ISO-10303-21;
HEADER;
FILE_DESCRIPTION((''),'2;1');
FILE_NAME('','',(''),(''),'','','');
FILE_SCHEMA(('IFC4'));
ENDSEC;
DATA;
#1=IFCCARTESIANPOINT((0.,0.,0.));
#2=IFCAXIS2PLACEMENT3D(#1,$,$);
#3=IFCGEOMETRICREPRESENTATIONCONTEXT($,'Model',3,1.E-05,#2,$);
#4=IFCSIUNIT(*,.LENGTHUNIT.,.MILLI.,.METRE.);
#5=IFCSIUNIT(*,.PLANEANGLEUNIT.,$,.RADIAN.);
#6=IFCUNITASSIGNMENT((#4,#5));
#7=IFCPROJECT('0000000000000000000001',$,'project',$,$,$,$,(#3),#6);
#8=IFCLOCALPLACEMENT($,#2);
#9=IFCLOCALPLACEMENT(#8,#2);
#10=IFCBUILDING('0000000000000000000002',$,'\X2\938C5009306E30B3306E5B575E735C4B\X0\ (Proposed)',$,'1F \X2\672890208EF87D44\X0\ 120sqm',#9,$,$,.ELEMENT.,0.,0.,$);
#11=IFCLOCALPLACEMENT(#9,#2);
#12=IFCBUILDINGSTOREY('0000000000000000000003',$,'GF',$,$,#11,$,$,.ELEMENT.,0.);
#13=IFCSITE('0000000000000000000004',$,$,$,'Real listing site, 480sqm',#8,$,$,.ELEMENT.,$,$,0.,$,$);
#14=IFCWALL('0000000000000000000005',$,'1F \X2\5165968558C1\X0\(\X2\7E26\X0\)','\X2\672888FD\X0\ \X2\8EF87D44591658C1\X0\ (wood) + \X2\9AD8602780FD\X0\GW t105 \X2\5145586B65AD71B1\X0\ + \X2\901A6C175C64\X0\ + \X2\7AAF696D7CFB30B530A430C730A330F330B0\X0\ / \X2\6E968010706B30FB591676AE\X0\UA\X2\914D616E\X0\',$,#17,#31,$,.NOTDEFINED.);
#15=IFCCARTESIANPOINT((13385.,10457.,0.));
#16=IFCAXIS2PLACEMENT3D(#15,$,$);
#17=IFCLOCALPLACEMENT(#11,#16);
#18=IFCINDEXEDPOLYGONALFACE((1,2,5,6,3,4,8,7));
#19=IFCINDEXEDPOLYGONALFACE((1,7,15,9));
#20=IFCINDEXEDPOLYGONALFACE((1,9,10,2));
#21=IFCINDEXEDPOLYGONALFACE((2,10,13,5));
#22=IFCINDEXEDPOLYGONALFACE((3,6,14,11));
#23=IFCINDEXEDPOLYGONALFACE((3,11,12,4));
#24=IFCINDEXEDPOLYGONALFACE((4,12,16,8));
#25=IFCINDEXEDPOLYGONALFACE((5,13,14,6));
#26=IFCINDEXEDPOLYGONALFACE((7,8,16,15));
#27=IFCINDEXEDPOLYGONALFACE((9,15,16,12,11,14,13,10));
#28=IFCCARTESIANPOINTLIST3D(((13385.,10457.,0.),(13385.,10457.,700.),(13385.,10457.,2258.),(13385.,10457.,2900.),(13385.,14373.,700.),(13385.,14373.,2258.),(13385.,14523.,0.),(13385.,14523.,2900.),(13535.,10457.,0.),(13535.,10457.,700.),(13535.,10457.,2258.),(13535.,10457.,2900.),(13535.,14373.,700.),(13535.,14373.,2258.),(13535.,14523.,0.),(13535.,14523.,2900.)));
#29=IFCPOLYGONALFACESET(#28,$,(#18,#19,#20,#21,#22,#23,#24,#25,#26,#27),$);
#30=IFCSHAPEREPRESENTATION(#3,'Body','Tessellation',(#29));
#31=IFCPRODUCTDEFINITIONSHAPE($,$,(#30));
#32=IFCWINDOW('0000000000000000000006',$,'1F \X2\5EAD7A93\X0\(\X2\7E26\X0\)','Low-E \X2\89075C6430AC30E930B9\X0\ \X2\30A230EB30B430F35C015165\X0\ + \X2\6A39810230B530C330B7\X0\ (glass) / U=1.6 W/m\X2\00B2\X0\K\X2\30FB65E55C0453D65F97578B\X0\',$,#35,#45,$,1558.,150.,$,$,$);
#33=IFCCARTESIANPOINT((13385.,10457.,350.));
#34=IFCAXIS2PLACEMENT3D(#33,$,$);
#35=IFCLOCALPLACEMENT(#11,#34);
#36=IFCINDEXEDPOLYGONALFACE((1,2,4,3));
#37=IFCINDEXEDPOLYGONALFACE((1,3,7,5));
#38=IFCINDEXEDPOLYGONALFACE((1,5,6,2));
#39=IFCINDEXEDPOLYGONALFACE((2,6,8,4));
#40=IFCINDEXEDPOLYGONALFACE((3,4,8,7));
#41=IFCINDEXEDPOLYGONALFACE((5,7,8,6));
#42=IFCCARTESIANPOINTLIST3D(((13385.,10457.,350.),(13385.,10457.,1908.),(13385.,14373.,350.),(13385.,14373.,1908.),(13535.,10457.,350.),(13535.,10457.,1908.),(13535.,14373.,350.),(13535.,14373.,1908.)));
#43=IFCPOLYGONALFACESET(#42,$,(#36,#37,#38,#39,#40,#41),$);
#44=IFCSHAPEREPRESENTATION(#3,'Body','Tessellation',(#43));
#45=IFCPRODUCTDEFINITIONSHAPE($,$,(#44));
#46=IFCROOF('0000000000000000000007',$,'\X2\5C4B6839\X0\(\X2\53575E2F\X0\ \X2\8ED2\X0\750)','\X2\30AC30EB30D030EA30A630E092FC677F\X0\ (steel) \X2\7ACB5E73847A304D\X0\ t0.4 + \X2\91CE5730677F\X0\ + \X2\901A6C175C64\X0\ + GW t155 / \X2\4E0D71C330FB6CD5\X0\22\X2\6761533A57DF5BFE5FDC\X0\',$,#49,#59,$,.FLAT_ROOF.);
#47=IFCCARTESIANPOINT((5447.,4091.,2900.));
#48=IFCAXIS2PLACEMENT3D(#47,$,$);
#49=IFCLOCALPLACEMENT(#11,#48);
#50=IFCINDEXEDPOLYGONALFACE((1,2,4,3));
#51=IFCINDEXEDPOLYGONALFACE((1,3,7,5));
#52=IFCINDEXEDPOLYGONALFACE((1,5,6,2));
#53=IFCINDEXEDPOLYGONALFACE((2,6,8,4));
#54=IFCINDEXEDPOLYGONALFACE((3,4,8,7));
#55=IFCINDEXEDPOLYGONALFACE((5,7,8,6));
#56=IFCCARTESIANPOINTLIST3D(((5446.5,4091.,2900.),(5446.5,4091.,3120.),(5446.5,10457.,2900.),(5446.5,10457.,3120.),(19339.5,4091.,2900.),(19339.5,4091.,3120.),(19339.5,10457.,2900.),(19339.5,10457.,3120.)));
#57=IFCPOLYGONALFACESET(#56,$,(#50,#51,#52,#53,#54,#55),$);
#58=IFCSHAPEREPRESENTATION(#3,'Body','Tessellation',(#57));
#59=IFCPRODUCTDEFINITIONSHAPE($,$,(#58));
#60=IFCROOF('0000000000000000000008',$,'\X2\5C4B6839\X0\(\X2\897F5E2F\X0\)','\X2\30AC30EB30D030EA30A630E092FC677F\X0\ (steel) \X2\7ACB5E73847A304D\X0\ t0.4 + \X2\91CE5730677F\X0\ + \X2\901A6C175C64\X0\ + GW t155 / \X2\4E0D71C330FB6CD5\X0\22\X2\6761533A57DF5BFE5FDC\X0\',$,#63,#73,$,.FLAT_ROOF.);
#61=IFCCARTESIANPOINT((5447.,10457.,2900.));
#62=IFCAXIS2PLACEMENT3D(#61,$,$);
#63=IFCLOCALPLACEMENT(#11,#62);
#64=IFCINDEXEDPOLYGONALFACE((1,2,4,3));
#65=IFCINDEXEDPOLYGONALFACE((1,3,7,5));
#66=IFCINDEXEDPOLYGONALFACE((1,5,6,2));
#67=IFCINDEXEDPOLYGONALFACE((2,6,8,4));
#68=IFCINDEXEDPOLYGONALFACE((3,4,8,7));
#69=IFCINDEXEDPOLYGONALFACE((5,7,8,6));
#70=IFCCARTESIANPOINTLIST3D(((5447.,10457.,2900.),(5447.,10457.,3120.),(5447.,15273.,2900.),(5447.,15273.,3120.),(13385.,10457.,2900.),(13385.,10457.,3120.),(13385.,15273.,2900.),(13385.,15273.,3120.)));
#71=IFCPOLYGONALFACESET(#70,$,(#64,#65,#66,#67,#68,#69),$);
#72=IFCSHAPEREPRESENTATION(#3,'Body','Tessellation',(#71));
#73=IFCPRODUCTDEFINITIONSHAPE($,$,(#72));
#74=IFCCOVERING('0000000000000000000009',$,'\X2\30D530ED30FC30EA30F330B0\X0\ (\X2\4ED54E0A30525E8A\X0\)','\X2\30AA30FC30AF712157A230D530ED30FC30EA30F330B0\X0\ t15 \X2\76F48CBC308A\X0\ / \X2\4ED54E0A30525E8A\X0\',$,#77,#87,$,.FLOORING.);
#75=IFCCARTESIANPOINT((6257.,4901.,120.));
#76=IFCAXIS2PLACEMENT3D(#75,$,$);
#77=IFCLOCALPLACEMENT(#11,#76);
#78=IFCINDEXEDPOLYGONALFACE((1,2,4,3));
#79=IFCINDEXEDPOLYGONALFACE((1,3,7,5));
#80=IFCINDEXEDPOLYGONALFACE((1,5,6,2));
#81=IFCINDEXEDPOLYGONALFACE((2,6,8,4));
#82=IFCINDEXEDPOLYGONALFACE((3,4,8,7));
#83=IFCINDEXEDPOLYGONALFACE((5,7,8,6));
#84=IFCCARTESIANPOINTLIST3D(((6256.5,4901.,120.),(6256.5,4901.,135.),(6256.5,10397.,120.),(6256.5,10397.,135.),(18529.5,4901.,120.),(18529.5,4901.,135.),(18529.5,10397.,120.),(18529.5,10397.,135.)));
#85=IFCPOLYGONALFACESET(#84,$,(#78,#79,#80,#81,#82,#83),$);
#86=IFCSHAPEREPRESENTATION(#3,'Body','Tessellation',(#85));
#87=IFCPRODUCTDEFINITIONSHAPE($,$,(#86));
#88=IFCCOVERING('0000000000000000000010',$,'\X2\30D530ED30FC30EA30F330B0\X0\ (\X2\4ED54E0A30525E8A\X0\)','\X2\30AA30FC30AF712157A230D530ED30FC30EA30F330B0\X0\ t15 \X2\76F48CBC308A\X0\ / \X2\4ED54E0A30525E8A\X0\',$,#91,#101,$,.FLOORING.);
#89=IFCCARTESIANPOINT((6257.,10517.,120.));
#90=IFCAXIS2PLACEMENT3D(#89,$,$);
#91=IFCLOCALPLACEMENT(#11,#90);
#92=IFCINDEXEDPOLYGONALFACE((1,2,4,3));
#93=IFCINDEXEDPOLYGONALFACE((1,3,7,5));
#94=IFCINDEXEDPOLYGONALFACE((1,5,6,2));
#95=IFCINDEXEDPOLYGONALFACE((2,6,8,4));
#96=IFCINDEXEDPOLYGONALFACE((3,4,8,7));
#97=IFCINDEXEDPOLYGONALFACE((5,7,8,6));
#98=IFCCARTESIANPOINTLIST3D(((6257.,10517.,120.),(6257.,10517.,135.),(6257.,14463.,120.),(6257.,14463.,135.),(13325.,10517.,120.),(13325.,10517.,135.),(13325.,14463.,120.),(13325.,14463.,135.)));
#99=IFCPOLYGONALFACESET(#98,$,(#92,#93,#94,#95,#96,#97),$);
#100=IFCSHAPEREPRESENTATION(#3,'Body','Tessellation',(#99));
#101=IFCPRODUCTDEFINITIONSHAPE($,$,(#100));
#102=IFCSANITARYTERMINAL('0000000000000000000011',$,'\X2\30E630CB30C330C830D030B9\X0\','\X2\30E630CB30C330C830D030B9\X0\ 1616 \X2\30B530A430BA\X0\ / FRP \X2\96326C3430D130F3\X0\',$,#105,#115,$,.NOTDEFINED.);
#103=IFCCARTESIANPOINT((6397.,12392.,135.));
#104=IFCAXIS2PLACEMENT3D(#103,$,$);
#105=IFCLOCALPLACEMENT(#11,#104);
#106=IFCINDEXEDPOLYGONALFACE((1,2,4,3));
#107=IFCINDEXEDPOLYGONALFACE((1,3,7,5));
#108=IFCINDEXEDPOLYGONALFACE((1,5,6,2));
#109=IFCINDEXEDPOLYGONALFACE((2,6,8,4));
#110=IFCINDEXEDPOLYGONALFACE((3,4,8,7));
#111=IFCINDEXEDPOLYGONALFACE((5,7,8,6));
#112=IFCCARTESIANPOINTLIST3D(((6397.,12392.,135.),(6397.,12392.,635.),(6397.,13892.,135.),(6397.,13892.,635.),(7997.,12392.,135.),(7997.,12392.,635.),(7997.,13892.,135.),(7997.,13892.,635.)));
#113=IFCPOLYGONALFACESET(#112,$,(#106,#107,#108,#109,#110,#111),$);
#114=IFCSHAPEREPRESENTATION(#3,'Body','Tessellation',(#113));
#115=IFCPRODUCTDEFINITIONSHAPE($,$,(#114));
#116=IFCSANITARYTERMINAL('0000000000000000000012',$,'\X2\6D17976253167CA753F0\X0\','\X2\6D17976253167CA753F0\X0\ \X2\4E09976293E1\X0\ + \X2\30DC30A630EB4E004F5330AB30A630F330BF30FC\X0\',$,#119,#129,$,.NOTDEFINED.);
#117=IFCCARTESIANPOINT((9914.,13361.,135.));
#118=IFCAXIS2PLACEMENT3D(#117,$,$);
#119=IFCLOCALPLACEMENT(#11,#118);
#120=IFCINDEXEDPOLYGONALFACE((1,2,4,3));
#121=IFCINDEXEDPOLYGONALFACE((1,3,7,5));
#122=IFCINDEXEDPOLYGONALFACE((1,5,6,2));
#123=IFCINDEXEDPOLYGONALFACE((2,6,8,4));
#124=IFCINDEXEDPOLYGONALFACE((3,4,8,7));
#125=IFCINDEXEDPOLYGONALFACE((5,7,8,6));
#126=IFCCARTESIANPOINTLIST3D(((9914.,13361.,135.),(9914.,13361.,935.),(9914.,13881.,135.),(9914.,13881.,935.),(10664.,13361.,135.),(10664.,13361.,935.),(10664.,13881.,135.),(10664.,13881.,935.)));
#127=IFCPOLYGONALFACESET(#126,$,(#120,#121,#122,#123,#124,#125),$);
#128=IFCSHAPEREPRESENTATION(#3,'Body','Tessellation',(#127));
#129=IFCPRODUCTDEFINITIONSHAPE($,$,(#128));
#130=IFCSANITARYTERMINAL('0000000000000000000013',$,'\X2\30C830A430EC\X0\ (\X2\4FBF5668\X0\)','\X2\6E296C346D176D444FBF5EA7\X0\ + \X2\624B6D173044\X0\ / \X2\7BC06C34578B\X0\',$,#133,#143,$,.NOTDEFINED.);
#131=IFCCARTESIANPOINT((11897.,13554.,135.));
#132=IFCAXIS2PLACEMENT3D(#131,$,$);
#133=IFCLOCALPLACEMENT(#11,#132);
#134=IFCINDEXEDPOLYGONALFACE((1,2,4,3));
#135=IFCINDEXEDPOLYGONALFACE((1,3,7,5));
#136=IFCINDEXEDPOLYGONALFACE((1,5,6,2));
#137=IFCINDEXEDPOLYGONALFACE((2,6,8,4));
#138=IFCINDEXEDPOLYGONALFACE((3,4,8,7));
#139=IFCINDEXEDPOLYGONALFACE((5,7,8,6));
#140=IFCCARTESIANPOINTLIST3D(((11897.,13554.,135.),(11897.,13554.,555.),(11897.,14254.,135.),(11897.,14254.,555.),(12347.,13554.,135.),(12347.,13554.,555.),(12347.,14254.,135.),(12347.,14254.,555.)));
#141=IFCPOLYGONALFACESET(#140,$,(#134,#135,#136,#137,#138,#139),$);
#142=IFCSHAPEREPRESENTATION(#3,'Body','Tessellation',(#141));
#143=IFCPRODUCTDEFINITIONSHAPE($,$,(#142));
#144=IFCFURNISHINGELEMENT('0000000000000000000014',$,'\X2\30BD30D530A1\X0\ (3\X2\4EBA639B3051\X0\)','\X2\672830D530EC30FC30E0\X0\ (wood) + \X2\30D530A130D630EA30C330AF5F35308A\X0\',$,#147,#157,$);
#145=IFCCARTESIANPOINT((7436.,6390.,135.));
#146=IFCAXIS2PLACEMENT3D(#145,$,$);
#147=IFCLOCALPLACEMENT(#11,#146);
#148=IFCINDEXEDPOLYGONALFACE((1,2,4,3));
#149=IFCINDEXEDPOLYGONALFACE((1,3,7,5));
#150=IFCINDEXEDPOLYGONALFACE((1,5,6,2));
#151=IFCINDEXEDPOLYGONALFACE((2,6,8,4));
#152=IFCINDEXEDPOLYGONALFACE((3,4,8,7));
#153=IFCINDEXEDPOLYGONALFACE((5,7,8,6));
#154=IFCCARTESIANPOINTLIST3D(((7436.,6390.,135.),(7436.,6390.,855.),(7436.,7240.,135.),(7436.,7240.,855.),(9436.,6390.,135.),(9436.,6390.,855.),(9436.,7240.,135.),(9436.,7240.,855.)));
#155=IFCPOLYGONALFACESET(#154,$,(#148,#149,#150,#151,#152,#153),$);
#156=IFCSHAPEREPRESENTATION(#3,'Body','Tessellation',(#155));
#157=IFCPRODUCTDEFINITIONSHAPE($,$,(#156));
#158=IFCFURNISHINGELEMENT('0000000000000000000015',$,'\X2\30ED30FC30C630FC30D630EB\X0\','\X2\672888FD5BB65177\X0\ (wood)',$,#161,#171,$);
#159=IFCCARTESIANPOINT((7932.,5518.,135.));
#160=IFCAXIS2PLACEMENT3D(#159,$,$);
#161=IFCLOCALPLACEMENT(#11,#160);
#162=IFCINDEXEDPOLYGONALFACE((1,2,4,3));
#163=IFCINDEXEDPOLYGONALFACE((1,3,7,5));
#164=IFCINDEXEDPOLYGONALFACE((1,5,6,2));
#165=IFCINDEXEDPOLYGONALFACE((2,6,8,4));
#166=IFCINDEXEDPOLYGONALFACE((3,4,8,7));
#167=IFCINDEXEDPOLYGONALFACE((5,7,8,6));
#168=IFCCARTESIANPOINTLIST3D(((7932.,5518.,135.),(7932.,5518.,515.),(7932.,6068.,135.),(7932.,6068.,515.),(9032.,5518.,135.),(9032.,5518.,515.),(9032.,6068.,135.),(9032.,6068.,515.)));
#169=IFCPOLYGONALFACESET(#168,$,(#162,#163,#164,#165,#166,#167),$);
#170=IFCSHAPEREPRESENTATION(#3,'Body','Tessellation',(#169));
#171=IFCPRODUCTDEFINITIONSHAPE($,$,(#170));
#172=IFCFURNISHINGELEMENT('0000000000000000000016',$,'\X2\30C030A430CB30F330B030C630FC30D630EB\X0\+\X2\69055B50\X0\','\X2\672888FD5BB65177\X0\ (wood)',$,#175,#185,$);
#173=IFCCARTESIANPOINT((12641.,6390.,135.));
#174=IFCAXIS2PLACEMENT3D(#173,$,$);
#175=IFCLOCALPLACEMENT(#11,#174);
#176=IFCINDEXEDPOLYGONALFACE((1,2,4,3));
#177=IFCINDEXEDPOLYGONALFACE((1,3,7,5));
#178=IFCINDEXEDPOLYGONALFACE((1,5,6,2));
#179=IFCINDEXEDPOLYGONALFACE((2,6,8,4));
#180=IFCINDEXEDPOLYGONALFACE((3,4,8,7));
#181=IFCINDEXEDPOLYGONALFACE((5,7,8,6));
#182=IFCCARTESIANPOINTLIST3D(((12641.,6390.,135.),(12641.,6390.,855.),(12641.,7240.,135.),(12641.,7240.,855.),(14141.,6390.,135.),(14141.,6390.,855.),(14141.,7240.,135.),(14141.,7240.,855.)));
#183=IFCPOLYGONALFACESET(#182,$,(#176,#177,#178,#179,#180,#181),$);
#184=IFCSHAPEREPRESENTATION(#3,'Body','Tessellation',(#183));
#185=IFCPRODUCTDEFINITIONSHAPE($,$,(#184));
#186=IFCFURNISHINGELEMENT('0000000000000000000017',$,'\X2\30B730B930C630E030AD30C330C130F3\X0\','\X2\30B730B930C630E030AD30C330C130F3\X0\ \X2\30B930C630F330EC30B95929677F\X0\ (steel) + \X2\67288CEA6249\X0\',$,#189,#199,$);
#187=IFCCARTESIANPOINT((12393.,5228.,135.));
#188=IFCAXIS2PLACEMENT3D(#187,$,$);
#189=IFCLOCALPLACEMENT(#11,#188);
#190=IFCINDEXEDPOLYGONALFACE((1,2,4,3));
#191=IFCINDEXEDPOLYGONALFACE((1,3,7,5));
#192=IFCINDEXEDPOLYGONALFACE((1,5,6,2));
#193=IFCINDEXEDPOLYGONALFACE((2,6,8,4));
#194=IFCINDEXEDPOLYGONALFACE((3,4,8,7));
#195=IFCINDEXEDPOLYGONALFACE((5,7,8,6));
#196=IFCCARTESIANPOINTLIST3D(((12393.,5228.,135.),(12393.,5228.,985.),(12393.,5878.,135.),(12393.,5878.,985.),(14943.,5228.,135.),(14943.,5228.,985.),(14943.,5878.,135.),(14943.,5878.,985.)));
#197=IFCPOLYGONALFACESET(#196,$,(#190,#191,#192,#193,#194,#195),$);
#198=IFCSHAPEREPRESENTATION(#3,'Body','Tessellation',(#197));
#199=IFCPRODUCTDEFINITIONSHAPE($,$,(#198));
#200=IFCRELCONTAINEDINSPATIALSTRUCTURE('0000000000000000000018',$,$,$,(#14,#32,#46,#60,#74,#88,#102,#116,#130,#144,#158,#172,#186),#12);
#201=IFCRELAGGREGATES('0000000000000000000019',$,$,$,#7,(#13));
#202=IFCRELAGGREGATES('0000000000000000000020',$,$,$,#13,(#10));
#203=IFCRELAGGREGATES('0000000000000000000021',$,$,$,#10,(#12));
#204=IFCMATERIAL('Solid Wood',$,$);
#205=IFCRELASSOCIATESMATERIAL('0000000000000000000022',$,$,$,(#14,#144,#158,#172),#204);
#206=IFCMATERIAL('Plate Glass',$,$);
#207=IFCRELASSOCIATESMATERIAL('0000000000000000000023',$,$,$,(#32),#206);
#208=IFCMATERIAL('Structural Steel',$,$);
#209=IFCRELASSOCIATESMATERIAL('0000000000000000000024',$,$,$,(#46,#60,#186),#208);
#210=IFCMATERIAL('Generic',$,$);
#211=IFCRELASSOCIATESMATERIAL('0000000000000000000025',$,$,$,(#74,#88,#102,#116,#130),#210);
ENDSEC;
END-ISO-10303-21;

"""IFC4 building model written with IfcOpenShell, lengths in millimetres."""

from ifc_helpers import new_model, si_unit, frame, frame_2d, origin, place, context, project, spatial, rectangle, extrude, material, element, fill, save


model = new_model("IFC4")

# Units and contexts
model_context = context("Model", 3, precision=1e-05, world=origin())
ifc_project = project(units=[si_unit("LENGTHUNIT", "METRE", prefix="MILLI"), si_unit("PLANEANGLEUNIT", "RADIAN")], contexts=[model_context])

# Site, building, storey
site_placement = place(None, origin())
site = spatial("IfcSite", under=ifc_project, at=site_placement, ObjectType="Real listing site, 480sqm", CompositionType="ELEMENT", RefElevation=0.0)
building_placement = place(site_placement, origin())
building = spatial("IfcBuilding", under=site, at=building_placement, Name="鎌倉のコの字平屋 (Proposed)", ObjectType="1F 木造軸組 120sqm", CompositionType="ELEMENT", ElevationOfRefHeight=0.0, ElevationOfTerrain=0.0)
storey_placement = place(building_placement, origin())
storey = spatial("IfcBuildingStorey", under=building, at=storey_placement, Name="GF", CompositionType="ELEMENT", Elevation=0.0)

# Shared definitions
ifc_material_1 = material(Name="Solid Wood")

# Shared definitions
ifc_material_2 = material(Name="Plate Glass")

# Wall, opening, window
wall_1_placement = place(storey_placement, frame((13385.0, 10457.0, 0.0)))
wall_1 = element("IfcWall", 1, at=wall_1_placement, inside=storey, material=ifc_material_1, Name="1F 入隅壁(縦)", Description="木製 軸組外壁 (wood) + 高性能GW t105 充填断熱 + 通気層 + 窯業系サイディング / 準耐火・外皮UA配慮", PredefinedType="NOTDEFINED", context=model_context, shape_type="SweptSolid", body=[
    extrude(rectangle(XDim=150.0, YDim=4066.0, at=frame_2d((75.0, 2033.0))), frame((13385.0, 10457.0, 0.0)), (0.0, 0.0, 1.0), 2900.0),
])
opening_1_placement = place(storey_placement, frame((13385.0, 10457.0, 350.0)))
opening_1 = element("IfcOpeningElement", 2, at=opening_1_placement, cuts=wall_1, PredefinedType="NOTDEFINED", context=model_context, shape_type="SweptSolid", body=[
    extrude(rectangle(XDim=150.0, YDim=3916.0, at=frame_2d((75.0, 1958.0))), frame((13385.0, 10457.0, 350.0)), (0.0, 0.0, 1.0), 1558.0),
])
window_1_placement = place(storey_placement, frame((13385.0, 10457.0, 350.0)))
window_1 = element("IfcWindow", 3, at=window_1_placement, inside=storey, material=ifc_material_2, Name="1F 庭窓(縦)", Description="Low-E 複層ガラス アルゴン封入 + 樹脂サッシ (glass) / U=1.6 W/m²K・日射取得型", OverallHeight=1558.0, OverallWidth=150.0, context=model_context, shape_type="SweptSolid", body=[
    extrude(rectangle(XDim=150.0, YDim=3916.0, at=frame_2d((75.0, 1958.0))), frame((13385.0, 10457.0, 350.0)), (0.0, 0.0, 1.0), 1558.0),
])
fill(opening_1, window_1)

# Roofs
ifc_material_3 = material(Name="Structural Steel")
roof_1_placement = place(storey_placement, frame((5447.0, 4091.0, 2900.0)))
element("IfcRoof", 4, at=roof_1_placement, inside=storey, material=ifc_material_3, Name="屋根(南帯 軒750)", Description="ガルバリウム鋼板 (steel) 立平葺き t0.4 + 野地板 + 通気層 + GW t155 / 不燃・法22条区域対応", PredefinedType="FLAT_ROOF", context=model_context, shape_type="SweptSolid", body=[
    extrude(rectangle(XDim=13893.0, YDim=6366.0, at=frame_2d((6946.0, 3183.0))), frame((5447.0, 4091.0, 2900.0)), (0.0, 0.0, 1.0), 220.0),
])
roof_2_placement = place(storey_placement, frame((5447.0, 10457.0, 2900.0)))
element("IfcRoof", 5, at=roof_2_placement, inside=storey, material=ifc_material_3, Name="屋根(西帯)", Description="ガルバリウム鋼板 (steel) 立平葺き t0.4 + 野地板 + 通気層 + GW t155 / 不燃・法22条区域対応", PredefinedType="FLAT_ROOF", context=model_context, shape_type="SweptSolid", body=[
    extrude(rectangle(XDim=7938.0, YDim=4816.0, at=frame_2d((3969.0, 2408.0))), frame((5447.0, 10457.0, 2900.0)), (0.0, 0.0, 1.0), 220.0),
])

# Coverings
ifc_material_4 = material(Name="Generic")
covering_1_placement = place(storey_placement, frame((6257.0, 4901.0, 120.0)))
element("IfcCovering", 6, at=covering_1_placement, inside=storey, material=ifc_material_4, Name="フローリング (仕上げ床)", Description="オーク無垢フローリング t15 直貼り / 仕上げ床", PredefinedType="FLOORING", context=model_context, shape_type="SweptSolid", body=[
    extrude(rectangle(XDim=12273.0, YDim=5496.0, at=frame_2d((6136.0, 2748.0))), frame((6257.0, 4901.0, 120.0)), (0.0, 0.0, 1.0), 15.0),
])
covering_2_placement = place(storey_placement, frame((6257.0, 10517.0, 120.0)))
element("IfcCovering", 7, at=covering_2_placement, inside=storey, material=ifc_material_4, Name="フローリング (仕上げ床)", Description="オーク無垢フローリング t15 直貼り / 仕上げ床", PredefinedType="FLOORING", context=model_context, shape_type="SweptSolid", body=[
    extrude(rectangle(XDim=7068.0, YDim=3946.0, at=frame_2d((3534.0, 1973.0))), frame((6257.0, 10517.0, 120.0)), (0.0, 0.0, 1.0), 15.0),
])

# Sanitary terminals
sanitary_terminal_1_placement = place(storey_placement, frame((6397.0, 12392.0, 135.0)))
element("IfcSanitaryTerminal", 8, at=sanitary_terminal_1_placement, inside=storey, material=ifc_material_4, Name="ユニットバス", Description="ユニットバス 1616 サイズ / FRP 防水パン", PredefinedType="NOTDEFINED", context=model_context, shape_type="SweptSolid", body=[
    extrude(rectangle(XDim=1600.0, YDim=1500.0, at=frame_2d((800.0, 750.0))), frame((6397.0, 12392.0, 135.0)), (0.0, 0.0, 1.0), 500.0),
])
sanitary_terminal_2_placement = place(storey_placement, frame((9914.0, 13361.0, 135.0)))
element("IfcSanitaryTerminal", 9, at=sanitary_terminal_2_placement, inside=storey, material=ifc_material_4, Name="洗面化粧台", Description="洗面化粧台 三面鏡 + ボウル一体カウンター", PredefinedType="NOTDEFINED", context=model_context, shape_type="SweptSolid", body=[
    extrude(rectangle(XDim=750.0, YDim=520.0, at=frame_2d((375.0, 260.0))), frame((9914.0, 13361.0, 135.0)), (0.0, 0.0, 1.0), 800.0),
])
sanitary_terminal_3_placement = place(storey_placement, frame((11897.0, 13554.0, 135.0)))
element("IfcSanitaryTerminal", 10, at=sanitary_terminal_3_placement, inside=storey, material=ifc_material_4, Name="トイレ (便器)", Description="温水洗浄便座 + 手洗い / 節水型", PredefinedType="NOTDEFINED", context=model_context, shape_type="SweptSolid", body=[
    extrude(rectangle(XDim=450.0, YDim=700.0, at=frame_2d((225.0, 350.0))), frame((11897.0, 13554.0, 135.0)), (0.0, 0.0, 1.0), 420.0),
])

# Furnishing elements
furnishing_1_placement = place(storey_placement, frame((7436.0, 6390.0, 135.0)))
element("IfcFurnishingElement", 11, at=furnishing_1_placement, inside=storey, material=ifc_material_1, Name="ソファ (3人掛け)", Description="木フレーム (wood) + ファブリック張り", context=model_context, shape_type="SweptSolid", body=[
    extrude(rectangle(XDim=2000.0, YDim=850.0, at=frame_2d((1000.0, 425.0))), frame((7436.0, 6390.0, 135.0)), (0.0, 0.0, 1.0), 720.0),
])
furnishing_2_placement = place(storey_placement, frame((7932.0, 5518.0, 135.0)))
element("IfcFurnishingElement", 12, at=furnishing_2_placement, inside=storey, material=ifc_material_1, Name="ローテーブル", Description="木製家具 (wood)", context=model_context, shape_type="SweptSolid", body=[
    extrude(rectangle(XDim=1100.0, YDim=550.0, at=frame_2d((550.0, 275.0))), frame((7932.0, 5518.0, 135.0)), (0.0, 0.0, 1.0), 380.0),
])
furnishing_3_placement = place(storey_placement, frame((12641.0, 6390.0, 135.0)))
element("IfcFurnishingElement", 13, at=furnishing_3_placement, inside=storey, material=ifc_material_1, Name="ダイニングテーブル+椅子", Description="木製家具 (wood)", context=model_context, shape_type="SweptSolid", body=[
    extrude(rectangle(XDim=1500.0, YDim=850.0, at=frame_2d((750.0, 425.0))), frame((12641.0, 6390.0, 135.0)), (0.0, 0.0, 1.0), 720.0),
])
furnishing_4_placement = place(storey_placement, frame((12393.0, 5228.0, 135.0)))
element("IfcFurnishingElement", 14, at=furnishing_4_placement, inside=storey, material=ifc_material_3, Name="システムキッチン", Description="システムキッチン ステンレス天板 (steel) + 木質扉", context=model_context, shape_type="SweptSolid", body=[
    extrude(rectangle(XDim=2550.0, YDim=650.0, at=frame_2d((1275.0, 325.0))), frame((12393.0, 5228.0, 135.0)), (0.0, 0.0, 1.0), 850.0),
])

save(model, "model.ifc")
